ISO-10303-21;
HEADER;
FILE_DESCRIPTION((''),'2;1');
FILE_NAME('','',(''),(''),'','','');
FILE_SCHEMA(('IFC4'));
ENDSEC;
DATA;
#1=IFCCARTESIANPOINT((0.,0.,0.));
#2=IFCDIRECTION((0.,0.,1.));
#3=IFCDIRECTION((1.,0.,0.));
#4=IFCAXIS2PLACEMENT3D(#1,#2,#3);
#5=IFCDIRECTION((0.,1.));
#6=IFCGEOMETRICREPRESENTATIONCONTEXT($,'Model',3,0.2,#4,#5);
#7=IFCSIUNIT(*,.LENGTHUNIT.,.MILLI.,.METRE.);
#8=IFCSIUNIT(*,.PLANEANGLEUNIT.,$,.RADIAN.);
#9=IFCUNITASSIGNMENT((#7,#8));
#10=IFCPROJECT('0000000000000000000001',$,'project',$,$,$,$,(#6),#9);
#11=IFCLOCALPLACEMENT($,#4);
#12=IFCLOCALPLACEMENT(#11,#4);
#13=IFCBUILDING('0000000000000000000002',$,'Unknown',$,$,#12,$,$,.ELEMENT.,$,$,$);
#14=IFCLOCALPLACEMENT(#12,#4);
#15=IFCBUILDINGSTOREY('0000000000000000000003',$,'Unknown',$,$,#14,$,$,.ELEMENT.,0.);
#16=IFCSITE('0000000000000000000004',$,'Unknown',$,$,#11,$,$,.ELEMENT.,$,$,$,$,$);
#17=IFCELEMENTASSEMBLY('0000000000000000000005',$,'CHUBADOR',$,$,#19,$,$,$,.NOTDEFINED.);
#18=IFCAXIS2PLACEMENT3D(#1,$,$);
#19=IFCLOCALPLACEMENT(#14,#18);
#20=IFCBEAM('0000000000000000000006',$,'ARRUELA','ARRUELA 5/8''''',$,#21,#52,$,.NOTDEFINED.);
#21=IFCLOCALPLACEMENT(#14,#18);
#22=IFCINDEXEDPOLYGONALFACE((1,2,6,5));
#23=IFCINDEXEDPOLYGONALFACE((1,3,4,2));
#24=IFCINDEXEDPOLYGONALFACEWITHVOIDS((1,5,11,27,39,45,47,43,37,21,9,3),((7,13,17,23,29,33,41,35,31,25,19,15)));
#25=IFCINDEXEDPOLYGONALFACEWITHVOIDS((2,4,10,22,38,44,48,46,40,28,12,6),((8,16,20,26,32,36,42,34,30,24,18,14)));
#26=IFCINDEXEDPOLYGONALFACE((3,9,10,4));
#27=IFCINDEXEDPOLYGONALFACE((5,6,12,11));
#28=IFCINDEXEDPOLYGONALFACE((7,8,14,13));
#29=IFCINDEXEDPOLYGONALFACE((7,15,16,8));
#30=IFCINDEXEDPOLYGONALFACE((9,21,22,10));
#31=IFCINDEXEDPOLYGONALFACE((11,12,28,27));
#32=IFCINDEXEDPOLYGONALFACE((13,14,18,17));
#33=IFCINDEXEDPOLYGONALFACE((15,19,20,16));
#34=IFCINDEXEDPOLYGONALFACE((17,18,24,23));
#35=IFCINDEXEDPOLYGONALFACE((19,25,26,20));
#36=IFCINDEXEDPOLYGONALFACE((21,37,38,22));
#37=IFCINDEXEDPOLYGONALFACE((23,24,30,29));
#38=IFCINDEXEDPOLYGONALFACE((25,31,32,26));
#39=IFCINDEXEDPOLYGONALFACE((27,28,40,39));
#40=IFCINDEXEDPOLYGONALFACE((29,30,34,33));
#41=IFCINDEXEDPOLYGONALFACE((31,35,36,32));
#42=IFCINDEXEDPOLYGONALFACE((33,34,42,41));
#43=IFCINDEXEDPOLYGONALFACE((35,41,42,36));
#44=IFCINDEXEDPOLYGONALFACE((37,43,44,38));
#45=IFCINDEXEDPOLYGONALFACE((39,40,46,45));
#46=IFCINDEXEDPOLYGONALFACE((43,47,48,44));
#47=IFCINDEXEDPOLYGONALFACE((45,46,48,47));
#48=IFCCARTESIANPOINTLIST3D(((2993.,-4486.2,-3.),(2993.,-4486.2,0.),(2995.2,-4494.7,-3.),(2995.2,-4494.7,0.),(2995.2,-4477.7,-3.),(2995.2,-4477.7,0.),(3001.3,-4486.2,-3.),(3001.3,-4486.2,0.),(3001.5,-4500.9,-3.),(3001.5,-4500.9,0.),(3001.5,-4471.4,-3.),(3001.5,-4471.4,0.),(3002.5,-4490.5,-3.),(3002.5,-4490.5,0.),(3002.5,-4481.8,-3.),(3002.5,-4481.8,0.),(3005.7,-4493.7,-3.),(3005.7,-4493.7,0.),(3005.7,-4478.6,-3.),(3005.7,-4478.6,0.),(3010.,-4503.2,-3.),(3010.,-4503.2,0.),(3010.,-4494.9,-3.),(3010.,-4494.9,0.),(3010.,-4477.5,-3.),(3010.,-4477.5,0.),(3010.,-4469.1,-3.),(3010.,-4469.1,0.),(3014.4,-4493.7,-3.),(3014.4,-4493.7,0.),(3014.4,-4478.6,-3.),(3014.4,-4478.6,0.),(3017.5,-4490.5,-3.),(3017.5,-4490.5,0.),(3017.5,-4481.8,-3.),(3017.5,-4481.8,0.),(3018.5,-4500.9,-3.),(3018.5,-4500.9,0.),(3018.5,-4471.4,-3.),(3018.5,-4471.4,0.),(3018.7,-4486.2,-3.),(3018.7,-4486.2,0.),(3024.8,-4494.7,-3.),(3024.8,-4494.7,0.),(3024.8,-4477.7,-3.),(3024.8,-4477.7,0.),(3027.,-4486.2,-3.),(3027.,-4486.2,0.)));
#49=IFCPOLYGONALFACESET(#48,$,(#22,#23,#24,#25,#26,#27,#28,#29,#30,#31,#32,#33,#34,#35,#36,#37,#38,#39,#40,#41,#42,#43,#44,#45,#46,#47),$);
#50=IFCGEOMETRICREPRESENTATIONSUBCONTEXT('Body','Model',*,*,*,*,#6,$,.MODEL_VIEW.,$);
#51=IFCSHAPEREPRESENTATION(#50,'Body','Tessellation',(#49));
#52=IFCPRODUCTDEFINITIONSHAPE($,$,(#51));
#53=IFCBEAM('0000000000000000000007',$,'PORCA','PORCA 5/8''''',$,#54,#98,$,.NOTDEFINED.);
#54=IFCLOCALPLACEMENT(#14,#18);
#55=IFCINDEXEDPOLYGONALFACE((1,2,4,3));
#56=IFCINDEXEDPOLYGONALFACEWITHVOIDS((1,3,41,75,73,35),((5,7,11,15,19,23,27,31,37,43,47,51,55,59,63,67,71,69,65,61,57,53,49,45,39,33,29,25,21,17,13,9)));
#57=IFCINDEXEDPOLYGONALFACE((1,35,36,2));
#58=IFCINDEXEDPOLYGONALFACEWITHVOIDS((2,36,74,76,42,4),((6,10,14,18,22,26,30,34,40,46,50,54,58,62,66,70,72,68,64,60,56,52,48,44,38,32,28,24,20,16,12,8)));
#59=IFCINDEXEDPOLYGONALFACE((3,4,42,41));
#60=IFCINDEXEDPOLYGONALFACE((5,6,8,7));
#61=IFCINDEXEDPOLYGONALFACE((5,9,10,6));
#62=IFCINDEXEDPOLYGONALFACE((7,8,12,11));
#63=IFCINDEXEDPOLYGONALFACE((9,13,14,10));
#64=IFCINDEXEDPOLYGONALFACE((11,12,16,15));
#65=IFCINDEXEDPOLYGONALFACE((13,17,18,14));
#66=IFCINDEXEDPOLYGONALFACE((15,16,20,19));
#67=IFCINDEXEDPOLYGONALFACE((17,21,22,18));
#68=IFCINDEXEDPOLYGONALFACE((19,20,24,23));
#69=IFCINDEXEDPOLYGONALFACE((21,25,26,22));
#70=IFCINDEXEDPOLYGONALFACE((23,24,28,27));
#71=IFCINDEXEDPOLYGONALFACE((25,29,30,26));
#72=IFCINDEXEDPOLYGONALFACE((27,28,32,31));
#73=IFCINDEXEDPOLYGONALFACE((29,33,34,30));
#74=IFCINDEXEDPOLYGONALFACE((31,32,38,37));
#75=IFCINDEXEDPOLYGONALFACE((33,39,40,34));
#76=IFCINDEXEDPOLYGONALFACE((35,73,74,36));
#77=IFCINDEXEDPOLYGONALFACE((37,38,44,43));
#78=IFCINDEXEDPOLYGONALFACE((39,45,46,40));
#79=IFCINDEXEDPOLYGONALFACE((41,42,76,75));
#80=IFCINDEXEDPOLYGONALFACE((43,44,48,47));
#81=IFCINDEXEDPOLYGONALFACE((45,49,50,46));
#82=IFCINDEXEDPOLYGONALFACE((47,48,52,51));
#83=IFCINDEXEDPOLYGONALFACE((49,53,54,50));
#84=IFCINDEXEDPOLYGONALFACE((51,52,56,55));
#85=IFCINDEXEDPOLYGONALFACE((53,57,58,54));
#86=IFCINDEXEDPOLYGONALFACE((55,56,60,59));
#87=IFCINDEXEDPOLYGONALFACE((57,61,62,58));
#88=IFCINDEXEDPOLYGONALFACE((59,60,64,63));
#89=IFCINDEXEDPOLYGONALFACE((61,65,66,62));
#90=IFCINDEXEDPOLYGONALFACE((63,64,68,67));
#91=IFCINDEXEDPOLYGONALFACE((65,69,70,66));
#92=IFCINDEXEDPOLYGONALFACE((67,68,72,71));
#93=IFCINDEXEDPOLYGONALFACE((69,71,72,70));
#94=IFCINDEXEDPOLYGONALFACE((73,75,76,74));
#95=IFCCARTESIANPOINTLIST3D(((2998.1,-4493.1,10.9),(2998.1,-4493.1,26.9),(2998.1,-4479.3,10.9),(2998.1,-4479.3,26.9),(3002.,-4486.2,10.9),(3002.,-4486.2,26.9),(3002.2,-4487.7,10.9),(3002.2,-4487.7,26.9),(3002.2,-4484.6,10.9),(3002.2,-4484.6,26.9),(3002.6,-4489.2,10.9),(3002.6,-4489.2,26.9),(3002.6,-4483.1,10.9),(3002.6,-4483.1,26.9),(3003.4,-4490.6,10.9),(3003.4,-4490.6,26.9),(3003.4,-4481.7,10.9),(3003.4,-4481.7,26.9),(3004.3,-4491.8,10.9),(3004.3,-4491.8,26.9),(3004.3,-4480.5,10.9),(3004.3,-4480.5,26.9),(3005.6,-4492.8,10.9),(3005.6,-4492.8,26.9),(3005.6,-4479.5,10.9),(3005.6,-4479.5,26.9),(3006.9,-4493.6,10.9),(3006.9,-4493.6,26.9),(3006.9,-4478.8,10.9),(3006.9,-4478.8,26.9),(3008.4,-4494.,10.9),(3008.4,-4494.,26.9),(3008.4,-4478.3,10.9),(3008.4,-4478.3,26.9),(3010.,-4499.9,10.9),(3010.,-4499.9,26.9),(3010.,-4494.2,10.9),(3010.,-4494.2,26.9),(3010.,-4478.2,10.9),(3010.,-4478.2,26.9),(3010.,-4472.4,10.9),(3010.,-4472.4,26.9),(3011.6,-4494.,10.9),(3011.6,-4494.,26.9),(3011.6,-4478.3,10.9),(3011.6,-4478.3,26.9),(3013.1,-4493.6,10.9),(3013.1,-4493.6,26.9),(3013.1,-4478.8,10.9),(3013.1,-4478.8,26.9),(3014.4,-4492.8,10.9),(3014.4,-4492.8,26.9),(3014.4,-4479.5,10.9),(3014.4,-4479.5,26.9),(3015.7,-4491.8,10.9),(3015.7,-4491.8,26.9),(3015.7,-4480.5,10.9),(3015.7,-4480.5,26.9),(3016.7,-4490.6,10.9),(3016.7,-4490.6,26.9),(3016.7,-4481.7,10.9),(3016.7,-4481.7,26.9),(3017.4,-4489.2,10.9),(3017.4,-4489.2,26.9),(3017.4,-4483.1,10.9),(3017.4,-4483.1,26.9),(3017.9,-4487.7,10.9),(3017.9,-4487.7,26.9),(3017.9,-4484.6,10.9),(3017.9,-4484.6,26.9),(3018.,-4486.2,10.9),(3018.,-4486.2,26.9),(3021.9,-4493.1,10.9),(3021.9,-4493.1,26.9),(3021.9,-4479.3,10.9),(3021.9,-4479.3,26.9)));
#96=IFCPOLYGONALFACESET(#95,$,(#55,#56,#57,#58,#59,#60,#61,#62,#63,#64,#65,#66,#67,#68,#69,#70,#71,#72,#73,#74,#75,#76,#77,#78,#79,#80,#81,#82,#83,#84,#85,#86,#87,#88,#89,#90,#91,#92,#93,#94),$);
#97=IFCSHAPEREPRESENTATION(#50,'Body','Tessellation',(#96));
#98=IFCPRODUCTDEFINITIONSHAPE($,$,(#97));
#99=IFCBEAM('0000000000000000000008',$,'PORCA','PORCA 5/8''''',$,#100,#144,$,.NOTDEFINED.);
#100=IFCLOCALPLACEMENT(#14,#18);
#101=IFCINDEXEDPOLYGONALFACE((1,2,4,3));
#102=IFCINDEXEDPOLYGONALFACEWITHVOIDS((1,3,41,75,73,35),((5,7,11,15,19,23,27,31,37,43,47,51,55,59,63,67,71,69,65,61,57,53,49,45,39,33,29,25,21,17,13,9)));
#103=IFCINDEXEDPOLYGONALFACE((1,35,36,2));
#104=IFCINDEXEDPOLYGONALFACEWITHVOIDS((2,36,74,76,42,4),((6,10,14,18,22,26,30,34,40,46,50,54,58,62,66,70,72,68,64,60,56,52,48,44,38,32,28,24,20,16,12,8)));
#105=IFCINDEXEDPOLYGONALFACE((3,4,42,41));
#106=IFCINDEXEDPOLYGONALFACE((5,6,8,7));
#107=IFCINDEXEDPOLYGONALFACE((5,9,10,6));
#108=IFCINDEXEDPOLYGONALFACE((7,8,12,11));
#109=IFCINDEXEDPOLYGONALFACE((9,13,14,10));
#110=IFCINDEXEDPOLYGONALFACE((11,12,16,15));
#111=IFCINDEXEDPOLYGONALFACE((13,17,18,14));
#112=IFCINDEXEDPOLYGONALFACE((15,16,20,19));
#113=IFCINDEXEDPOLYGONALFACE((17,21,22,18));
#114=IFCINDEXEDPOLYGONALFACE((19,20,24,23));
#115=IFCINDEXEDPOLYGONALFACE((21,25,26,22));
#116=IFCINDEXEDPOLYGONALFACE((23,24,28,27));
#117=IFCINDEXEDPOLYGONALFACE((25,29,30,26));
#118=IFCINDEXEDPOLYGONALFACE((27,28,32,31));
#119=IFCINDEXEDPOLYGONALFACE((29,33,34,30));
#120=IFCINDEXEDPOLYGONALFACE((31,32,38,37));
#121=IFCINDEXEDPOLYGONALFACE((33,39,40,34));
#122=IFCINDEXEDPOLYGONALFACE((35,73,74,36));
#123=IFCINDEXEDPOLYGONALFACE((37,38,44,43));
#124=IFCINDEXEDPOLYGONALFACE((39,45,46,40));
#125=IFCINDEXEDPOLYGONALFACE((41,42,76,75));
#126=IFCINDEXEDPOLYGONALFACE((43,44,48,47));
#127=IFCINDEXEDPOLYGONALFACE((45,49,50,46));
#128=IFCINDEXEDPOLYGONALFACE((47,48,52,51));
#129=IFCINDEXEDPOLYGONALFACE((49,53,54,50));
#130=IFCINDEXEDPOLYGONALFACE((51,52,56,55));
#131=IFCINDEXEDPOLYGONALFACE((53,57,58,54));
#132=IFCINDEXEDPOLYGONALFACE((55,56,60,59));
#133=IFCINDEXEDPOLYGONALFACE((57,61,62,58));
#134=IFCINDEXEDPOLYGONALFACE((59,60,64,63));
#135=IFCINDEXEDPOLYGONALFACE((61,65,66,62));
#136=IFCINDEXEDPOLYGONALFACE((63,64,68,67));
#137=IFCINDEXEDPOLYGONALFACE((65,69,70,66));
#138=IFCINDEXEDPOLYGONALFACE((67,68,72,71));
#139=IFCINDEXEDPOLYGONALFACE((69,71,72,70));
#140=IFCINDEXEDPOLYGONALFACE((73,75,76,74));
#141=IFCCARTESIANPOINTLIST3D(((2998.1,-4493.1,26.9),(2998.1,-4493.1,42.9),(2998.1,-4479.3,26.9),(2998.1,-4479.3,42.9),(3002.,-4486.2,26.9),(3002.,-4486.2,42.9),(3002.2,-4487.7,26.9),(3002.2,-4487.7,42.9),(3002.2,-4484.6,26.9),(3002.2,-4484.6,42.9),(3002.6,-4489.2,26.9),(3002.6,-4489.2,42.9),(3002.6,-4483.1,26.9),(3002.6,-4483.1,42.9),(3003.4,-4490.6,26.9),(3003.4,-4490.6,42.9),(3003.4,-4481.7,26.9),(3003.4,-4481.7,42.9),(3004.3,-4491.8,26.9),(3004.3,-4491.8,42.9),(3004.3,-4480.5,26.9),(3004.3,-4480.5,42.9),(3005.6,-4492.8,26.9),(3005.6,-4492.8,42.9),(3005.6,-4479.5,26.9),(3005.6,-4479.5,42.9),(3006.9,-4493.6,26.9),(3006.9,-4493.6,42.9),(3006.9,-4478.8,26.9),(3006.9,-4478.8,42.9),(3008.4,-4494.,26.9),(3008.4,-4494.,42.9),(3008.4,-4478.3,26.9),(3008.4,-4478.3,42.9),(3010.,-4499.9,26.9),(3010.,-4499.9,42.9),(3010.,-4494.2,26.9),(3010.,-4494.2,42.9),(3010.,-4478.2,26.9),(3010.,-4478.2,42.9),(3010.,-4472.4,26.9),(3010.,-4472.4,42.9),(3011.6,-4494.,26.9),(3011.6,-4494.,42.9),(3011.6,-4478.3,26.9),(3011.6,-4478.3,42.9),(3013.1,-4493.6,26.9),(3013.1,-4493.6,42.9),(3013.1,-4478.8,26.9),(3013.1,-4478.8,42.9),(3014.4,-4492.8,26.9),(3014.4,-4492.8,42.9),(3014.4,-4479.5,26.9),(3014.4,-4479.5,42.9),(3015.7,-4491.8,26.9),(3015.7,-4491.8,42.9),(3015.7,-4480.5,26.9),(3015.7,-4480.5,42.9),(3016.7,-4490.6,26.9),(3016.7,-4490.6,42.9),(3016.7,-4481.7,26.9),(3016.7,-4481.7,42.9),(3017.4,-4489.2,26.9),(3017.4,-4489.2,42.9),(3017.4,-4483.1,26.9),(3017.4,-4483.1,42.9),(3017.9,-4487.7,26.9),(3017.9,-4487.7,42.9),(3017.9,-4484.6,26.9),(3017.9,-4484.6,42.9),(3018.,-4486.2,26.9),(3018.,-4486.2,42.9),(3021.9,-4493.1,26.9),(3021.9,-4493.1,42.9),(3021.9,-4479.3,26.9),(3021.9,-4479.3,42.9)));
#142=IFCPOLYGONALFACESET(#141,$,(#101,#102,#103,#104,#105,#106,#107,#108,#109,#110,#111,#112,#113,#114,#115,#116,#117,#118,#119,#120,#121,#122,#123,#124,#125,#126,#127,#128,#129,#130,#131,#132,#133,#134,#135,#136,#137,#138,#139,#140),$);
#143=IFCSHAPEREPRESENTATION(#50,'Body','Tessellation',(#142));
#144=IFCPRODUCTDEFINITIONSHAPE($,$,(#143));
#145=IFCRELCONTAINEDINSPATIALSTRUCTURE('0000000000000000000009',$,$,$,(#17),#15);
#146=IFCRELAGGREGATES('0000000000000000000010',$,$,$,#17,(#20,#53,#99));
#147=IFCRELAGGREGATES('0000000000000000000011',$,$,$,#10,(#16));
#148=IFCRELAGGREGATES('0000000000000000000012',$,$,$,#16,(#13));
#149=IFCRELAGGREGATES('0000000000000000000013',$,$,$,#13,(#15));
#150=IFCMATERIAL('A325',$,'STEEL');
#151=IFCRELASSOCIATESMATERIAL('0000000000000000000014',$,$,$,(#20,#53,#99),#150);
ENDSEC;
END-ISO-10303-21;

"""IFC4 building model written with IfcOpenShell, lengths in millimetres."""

from ifc_helpers import new_model, si_unit, direction, frame, origin_with_axes, place, context, subcontext, project, spatial, line, indexed_curve, outline, extrude, material, element, aggregate, save


model = new_model("IFC4")

# Units and contexts
model_context = context("Model", 3, precision=0.2, world=origin_with_axes(), true_north=direction((0.0, 1.0)))
body_context = subcontext(model_context, "Body", "Model", "MODEL_VIEW")
ifc_project = project(units=[si_unit("LENGTHUNIT", "METRE", prefix="MILLI"), si_unit("PLANEANGLEUNIT", "RADIAN")], contexts=[model_context])

# Site, building, storey
site_placement = place(None, origin_with_axes())
site = spatial("IfcSite", under=ifc_project, at=site_placement, Name="Unknown", CompositionType="ELEMENT")
building_placement = place(site_placement, origin_with_axes())
building = spatial("IfcBuilding", under=site, at=building_placement, Name="Unknown", CompositionType="ELEMENT")
storey_placement = place(building_placement, origin_with_axes())
storey = spatial("IfcBuildingStorey", under=building, at=storey_placement, Name="Unknown", CompositionType="ELEMENT", Elevation=0.0)

# Element assembly, beams
ifc_material_1 = material(Name="A325", Category="STEEL")
assembly_1_placement = place(storey_placement, frame((3010.0, -4486.2, -44.2), z_axis=(-1.0, 0.0, 0.0), x_axis=(0.0, 0.0, -1.0)))
assembly_1 = element("IfcElementAssembly", 1, at=assembly_1_placement, inside=storey, Name="CHUBADOR", PredefinedType="NOTDEFINED")
beam_1_placement = place(assembly_1_placement, frame((-44.2, 0.0, 0.0), z_axis=(0.0, 0.0, 1.0), x_axis=(1.0, 0.0, 0.0)))
beam_1 = element("IfcBeam", 2, at=beam_1_placement, material=ifc_material_1, Name="ARRUELA", Description="ARRUELA 5/8''", PredefinedType="NOTDEFINED", context=body_context, shape_type="SolidModel", body=[
    extrude(outline(indexed_curve([(17.0, 0.0), (14.8, 8.5), (8.5, 14.8), (0.0, 17.0), (-8.5, 14.8), (-14.8, 8.5), (-17.0, 0.0), (-14.8, -8.5), (-8.5, -14.8), (0.0, -17.0), (8.5, -14.8), (14.8, -8.5)], segments=[line(1, 2, 3, 4, 5, 6, 7, 8, 9, 10, 11, 12, 1)]), holes=[indexed_curve([(8.7, 0.0), (7.5, -4.3), (4.3, -7.5), (0.0, -8.7), (-4.3, -7.5), (-7.5, -4.3), (-8.7, 0.0), (-7.5, 4.3), (-4.3, 7.5), (0.0, 8.7), (4.3, 7.5), (7.5, 4.3)], segments=[line(1, 2, 3, 4, 5, 6, 7, 8, 9, 10, 11, 12, 1)])]), frame((0.0, 0.0, 0.0), z_axis=(-1.0, 0.0, 0.0), x_axis=(0.0, 0.0, 1.0)), (0.0, 0.0, -1.0), 3.0),
])
beam_2_placement = place(assembly_1_placement, frame((-71.1, 0.0, 0.0), z_axis=(0.0, 0.0, 1.0), x_axis=(1.0, 0.0, 0.0)))
beam_2 = element("IfcBeam", 3, at=beam_2_placement, material=ifc_material_1, Name="PORCA", Description="PORCA 5/8''", PredefinedType="NOTDEFINED", context=body_context, shape_type="SolidModel", body=[
    extrude(outline(indexed_curve([(0.0, 13.8), (-11.9, 6.9), (-11.9, -6.9), (0.0, -13.8), (11.9, -6.9), (11.9, 6.9)], segments=[line(1, 2, 3, 4, 5, 6, 1)]), holes=[indexed_curve([(7.8, 1.6), (8.0, 0.0), (7.8, -1.6), (7.4, -3.1), (6.7, -4.4), (5.7, -5.7), (4.4, -6.7), (3.1, -7.4), (1.6, -7.8), (0.0, -8.0), (-1.6, -7.8), (-3.1, -7.4), (-4.4, -6.7), (-5.7, -5.7), (-6.7, -4.4), (-7.4, -3.1), (-7.8, -1.6), (-8.0, 0.0), (-7.8, 1.6), (-7.4, 3.1), (-6.7, 4.4), (-5.7, 5.7), (-4.4, 6.7), (-3.1, 7.4), (-1.6, 7.8), (0.0, 8.0), (1.6, 7.8), (3.1, 7.4), (4.4, 6.7), (5.7, 5.7), (6.7, 4.4), (7.4, 3.1)], segments=[line(1, 2, 3, 4, 5, 6, 7, 8, 9, 10, 11, 12, 13, 14, 15, 16, 17, 18, 19, 20, 21, 22, 23, 24, 25, 26, 27, 28, 29, 30, 31, 32, 1)])]), frame((0.0, 0.0, 0.0), z_axis=(-1.0, 0.0, 0.0), x_axis=(0.0, 0.0, 1.0)), (0.0, 0.0, -1.0), 16.0),
])
beam_3_placement = place(assembly_1_placement, frame((-87.1, 0.0, 0.0), z_axis=(0.0, 0.0, 1.0), x_axis=(1.0, 0.0, 0.0)))
beam_3 = element("IfcBeam", 4, at=beam_3_placement, material=ifc_material_1, Name="PORCA", Description="PORCA 5/8''", PredefinedType="NOTDEFINED", context=body_context, shape_type="SolidModel", body=[
    extrude(outline(indexed_curve([(0.0, 13.8), (-11.9, 6.9), (-11.9, -6.9), (0.0, -13.8), (11.9, -6.9), (11.9, 6.9)], segments=[line(1, 2, 3, 4, 5, 6, 1)]), holes=[indexed_curve([(7.8, 1.6), (8.0, 0.0), (7.8, -1.6), (7.4, -3.1), (6.7, -4.4), (5.7, -5.7), (4.4, -6.7), (3.1, -7.4), (1.6, -7.8), (0.0, -8.0), (-1.6, -7.8), (-3.1, -7.4), (-4.4, -6.7), (-5.7, -5.7), (-6.7, -4.4), (-7.4, -3.1), (-7.8, -1.6), (-8.0, 0.0), (-7.8, 1.6), (-7.4, 3.1), (-6.7, 4.4), (-5.7, 5.7), (-4.4, 6.7), (-3.1, 7.4), (-1.6, 7.8), (0.0, 8.0), (1.6, 7.8), (3.1, 7.4), (4.4, 6.7), (5.7, 5.7), (6.7, 4.4), (7.4, 3.1)], segments=[line(1, 2, 3, 4, 5, 6, 7, 8, 9, 10, 11, 12, 13, 14, 15, 16, 17, 18, 19, 20, 21, 22, 23, 24, 25, 26, 27, 28, 29, 30, 31, 32, 1)])]), frame((0.0, 0.0, 0.0), z_axis=(-1.0, 0.0, 0.0), x_axis=(0.0, 0.0, 1.0)), (0.0, 0.0, -1.0), 16.0),
])
aggregate(assembly_1, [beam_1, beam_2, beam_3])

save(model, "model.ifc")
